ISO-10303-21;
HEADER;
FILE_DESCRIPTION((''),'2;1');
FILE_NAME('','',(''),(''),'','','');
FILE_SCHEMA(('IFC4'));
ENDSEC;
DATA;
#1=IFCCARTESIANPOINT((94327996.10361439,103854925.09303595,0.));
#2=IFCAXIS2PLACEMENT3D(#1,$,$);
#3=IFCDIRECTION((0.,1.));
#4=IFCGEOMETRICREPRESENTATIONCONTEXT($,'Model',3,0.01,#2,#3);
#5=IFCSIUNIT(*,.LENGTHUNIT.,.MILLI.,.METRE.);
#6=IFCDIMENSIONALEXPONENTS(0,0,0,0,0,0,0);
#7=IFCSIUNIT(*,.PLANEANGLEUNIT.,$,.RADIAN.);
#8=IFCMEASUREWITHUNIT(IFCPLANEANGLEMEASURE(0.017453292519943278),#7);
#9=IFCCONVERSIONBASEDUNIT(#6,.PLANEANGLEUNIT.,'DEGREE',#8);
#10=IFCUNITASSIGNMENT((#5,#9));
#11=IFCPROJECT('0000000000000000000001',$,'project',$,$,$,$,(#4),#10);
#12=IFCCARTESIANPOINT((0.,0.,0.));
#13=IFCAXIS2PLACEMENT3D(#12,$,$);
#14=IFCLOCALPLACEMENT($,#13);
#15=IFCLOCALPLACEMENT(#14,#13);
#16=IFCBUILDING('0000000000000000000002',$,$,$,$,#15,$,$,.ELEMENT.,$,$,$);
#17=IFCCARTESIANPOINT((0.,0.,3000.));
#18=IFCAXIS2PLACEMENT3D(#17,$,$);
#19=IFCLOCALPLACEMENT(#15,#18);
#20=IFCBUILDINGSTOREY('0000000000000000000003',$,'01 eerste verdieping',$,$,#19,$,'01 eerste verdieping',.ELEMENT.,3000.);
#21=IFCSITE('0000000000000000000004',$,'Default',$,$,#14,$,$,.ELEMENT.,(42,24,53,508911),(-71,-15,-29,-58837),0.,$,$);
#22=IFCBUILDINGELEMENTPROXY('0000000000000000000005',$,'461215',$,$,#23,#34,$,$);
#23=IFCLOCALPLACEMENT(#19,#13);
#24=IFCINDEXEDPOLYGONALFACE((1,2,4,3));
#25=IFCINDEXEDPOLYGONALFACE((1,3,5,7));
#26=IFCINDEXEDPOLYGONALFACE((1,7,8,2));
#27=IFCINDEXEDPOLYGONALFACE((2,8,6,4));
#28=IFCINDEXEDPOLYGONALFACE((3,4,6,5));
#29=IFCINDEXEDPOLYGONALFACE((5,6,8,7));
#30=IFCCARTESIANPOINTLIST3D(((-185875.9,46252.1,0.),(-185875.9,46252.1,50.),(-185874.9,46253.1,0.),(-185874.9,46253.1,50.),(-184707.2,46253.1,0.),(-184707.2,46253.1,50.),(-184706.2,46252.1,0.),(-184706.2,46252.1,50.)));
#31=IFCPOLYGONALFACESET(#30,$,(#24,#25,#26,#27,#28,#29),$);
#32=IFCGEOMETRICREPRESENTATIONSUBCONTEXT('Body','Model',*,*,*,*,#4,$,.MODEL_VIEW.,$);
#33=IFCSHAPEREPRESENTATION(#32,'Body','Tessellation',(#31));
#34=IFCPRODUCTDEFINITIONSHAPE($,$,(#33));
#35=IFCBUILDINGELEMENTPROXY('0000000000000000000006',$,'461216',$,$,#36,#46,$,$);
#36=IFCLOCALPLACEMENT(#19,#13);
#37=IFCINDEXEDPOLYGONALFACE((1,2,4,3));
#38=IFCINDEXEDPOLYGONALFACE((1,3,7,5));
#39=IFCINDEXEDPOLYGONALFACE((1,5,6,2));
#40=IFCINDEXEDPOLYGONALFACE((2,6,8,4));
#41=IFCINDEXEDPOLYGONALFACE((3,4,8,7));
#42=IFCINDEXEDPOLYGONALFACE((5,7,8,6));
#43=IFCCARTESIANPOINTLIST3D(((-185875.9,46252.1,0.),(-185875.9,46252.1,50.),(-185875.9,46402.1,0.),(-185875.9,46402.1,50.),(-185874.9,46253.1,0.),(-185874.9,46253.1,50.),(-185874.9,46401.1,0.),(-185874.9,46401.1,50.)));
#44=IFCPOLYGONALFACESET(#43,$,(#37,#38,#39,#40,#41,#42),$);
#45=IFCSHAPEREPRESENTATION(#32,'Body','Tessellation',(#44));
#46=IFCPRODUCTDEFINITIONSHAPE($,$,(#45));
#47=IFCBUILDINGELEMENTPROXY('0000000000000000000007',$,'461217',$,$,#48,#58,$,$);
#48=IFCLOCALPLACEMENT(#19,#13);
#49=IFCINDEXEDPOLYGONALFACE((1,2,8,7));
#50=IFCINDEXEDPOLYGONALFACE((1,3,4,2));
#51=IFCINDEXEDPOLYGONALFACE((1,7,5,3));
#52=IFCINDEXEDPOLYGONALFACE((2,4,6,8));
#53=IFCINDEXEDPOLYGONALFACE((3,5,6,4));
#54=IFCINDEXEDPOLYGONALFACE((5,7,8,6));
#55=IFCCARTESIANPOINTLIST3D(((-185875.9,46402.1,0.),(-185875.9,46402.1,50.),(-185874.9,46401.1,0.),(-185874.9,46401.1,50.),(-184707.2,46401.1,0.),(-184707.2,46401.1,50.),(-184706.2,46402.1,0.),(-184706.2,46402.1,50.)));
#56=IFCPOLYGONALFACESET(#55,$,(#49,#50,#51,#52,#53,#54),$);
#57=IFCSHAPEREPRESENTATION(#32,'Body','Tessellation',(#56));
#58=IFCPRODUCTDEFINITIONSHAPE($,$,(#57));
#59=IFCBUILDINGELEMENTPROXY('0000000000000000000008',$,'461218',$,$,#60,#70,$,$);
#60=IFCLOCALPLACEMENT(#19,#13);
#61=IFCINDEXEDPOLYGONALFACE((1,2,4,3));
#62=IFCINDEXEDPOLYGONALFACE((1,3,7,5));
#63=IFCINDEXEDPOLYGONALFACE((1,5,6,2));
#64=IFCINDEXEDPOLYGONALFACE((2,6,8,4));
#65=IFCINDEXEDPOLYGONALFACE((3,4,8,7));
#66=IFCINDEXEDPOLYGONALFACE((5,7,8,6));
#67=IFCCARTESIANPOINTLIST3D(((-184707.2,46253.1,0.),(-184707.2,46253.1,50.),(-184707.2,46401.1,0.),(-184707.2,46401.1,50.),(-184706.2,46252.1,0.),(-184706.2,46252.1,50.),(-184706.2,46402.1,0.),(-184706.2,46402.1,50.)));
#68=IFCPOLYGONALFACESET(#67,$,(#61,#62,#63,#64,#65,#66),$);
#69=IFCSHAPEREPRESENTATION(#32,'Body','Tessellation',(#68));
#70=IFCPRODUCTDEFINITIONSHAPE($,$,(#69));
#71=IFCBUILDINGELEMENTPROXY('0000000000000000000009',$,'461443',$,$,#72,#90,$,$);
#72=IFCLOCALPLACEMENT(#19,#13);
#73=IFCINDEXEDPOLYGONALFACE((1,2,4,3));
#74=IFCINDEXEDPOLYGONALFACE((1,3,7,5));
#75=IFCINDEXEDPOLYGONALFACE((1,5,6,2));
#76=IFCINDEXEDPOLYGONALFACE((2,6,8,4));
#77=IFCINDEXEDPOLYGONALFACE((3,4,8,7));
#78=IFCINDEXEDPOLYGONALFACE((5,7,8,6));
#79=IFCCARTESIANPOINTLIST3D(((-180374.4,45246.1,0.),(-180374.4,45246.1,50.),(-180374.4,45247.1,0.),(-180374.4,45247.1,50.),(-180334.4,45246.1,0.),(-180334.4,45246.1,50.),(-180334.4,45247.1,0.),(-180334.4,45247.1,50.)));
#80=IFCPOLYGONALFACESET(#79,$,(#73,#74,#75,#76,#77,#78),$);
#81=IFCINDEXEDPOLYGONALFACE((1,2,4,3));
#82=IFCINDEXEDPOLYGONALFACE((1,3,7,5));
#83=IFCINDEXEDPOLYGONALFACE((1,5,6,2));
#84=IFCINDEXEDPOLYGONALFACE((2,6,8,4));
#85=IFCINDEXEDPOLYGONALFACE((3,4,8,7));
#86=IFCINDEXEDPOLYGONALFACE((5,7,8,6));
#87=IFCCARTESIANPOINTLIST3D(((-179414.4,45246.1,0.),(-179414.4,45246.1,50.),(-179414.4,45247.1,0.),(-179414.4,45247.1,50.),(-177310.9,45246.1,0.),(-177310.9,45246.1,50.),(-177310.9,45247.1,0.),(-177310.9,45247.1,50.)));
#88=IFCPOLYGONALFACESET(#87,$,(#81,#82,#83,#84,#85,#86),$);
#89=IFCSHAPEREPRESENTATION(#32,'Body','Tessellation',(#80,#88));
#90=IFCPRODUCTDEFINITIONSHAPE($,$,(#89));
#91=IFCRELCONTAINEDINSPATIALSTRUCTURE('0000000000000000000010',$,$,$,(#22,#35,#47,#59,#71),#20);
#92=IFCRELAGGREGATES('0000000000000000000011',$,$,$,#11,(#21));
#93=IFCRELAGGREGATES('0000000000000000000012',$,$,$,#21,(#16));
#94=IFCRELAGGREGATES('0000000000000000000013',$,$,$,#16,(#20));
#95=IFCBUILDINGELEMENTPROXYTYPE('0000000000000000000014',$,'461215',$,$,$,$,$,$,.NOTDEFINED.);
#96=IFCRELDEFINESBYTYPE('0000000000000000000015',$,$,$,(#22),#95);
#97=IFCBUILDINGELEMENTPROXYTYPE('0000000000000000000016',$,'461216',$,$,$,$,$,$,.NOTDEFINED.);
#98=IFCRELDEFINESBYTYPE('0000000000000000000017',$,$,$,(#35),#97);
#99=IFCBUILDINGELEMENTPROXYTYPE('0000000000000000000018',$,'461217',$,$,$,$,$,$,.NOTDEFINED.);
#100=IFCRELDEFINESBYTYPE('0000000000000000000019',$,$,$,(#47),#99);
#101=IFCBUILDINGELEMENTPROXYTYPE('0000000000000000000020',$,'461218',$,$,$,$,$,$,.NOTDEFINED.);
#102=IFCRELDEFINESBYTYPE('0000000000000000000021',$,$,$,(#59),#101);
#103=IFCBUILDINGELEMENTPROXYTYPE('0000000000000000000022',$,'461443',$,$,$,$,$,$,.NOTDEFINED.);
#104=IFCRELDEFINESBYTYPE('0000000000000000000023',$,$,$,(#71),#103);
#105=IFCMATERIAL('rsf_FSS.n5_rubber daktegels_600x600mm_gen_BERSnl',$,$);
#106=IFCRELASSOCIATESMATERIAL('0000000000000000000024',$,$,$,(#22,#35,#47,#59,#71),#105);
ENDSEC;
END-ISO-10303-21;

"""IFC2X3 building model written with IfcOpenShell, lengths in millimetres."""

from ifc_helpers import new_model, entity, si_unit, converted_unit, direction, frame, frame_2d, origin, place, context, subcontext, project, spatial, polyline, rectangle, outline, extrude, material, type_object, element, save


model = new_model("IFC2X3")

# Units and contexts
model_context = context("Model", 3, precision=0.01, world=frame((94327996.10361439, 103854925.09303595, 0.0)), true_north=direction((0.0, 1.0)))
body_context = subcontext(model_context, "Body", "Model", "MODEL_VIEW")
ifc_project = project(units=[si_unit("LENGTHUNIT", "METRE", prefix="MILLI"), converted_unit("PLANEANGLEUNIT", "DEGREE", entity("IfcPlaneAngleMeasure", 0.017453292519943278), si_unit("PLANEANGLEUNIT", "RADIAN"), dimensions=[0, 0, 0, 0, 0, 0, 0])], contexts=[model_context])

# Site, building, storey
site_placement = place(None, origin())
site = spatial("IfcSite", under=ifc_project, at=site_placement, Name="Default", CompositionType="ELEMENT", RefLatitude=(42, 24, 53, 508911), RefLongitude=(-71, -15, -29, -58837), RefElevation=0.0)
building_placement = place(site_placement, origin())
building = spatial("IfcBuilding", under=site, at=building_placement, CompositionType="ELEMENT")
storey_placement = place(building_placement, frame((0.0, 0.0, 3000.0)))
storey = spatial("IfcBuildingStorey", under=building, at=storey_placement, Name="01 eerste verdieping", LongName="01 eerste verdieping", CompositionType="ELEMENT", Elevation=3000.0)

# Building element proxies
ifc_material = material(Name="rsf_FSS.n5_rubber daktegels_600x600mm_gen_BERSnl")
building_element_proxy_type_1 = type_object("IfcBuildingElementProxyType", Name="461215", PredefinedType="NOTDEFINED")
proxy_1_placement = place(storey_placement, origin())
element("IfcBuildingElementProxy", 1, at=proxy_1_placement, inside=storey, type_object=building_element_proxy_type_1, material=ifc_material, Name="461215", context=body_context, shape_type="SweptSolid", body=[
    extrude(outline(polyline([(-584.8, -0.5), (584.8, -0.5), (583.8, 0.5), (-583.8, 0.5), (-584.8, -0.5)])), frame((-185291.1, 46252.6, 0.0)), (0.0, 0.0, 1.0), 50.0),
])
building_element_proxy_type_2 = type_object("IfcBuildingElementProxyType", Name="461216", PredefinedType="NOTDEFINED")
proxy_2_placement = place(storey_placement, origin())
element("IfcBuildingElementProxy", 2, at=proxy_2_placement, inside=storey, type_object=building_element_proxy_type_2, material=ifc_material, Name="461216", context=body_context, shape_type="SweptSolid", body=[
    extrude(outline(polyline([(-75.0, -0.5), (75.0, -0.5), (74.0, 0.5), (-74.0, 0.5), (-75.0, -0.5)])), frame((-185875.4, 46327.1, 0.0), z_axis=(0.0, 0.0, 1.0), x_axis=(0.0, -1.0, 0.0)), (0.0, 0.0, 1.0), 50.0),
])
building_element_proxy_type_3 = type_object("IfcBuildingElementProxyType", Name="461217", PredefinedType="NOTDEFINED")
proxy_3_placement = place(storey_placement, origin())
element("IfcBuildingElementProxy", 3, at=proxy_3_placement, inside=storey, type_object=building_element_proxy_type_3, material=ifc_material, Name="461217", context=body_context, shape_type="SweptSolid", body=[
    extrude(outline(polyline([(-584.8, -0.5), (584.8, -0.5), (583.8, 0.5), (-583.8, 0.5), (-584.8, -0.5)])), frame((-185291.1, 46401.6, 0.0), z_axis=(0.0, 0.0, 1.0), x_axis=(-1.0, 0.0, 0.0)), (0.0, 0.0, 1.0), 50.0),
])
building_element_proxy_type_4 = type_object("IfcBuildingElementProxyType", Name="461218", PredefinedType="NOTDEFINED")
proxy_4_placement = place(storey_placement, origin())
element("IfcBuildingElementProxy", 4, at=proxy_4_placement, inside=storey, type_object=building_element_proxy_type_4, material=ifc_material, Name="461218", context=body_context, shape_type="SweptSolid", body=[
    extrude(outline(polyline([(-75.0, -0.5), (75.0, -0.5), (74.0, 0.5), (-74.0, 0.5), (-75.0, -0.5)])), frame((-184706.7, 46327.1, 0.0), z_axis=(0.0, 0.0, 1.0), x_axis=(0.0, 1.0, 0.0)), (0.0, 0.0, 1.0), 50.0),
])
building_element_proxy_type_5 = type_object("IfcBuildingElementProxyType", Name="461443", PredefinedType="NOTDEFINED")
proxy_5_placement = place(storey_placement, origin())
element("IfcBuildingElementProxy", 5, at=proxy_5_placement, inside=storey, type_object=building_element_proxy_type_5, material=ifc_material, Name="461443", context=body_context, shape_type="SweptSolid", body=[
    extrude(rectangle(XDim=40.0, YDim=1.0, at=frame_2d((0.0, 0.0), x_axis=(1.0, 0.0))), frame((-180354.4, 45246.6, 0.0)), (0.0, 0.0, 1.0), 50.0),
    extrude(rectangle(XDim=2103.5, YDim=1.0, at=frame_2d((0.0, 0.0), x_axis=(1.0, 0.0))), frame((-178362.6, 45246.6, 0.0)), (0.0, 0.0, 1.0), 50.0),
])

save(model, "model.ifc")
